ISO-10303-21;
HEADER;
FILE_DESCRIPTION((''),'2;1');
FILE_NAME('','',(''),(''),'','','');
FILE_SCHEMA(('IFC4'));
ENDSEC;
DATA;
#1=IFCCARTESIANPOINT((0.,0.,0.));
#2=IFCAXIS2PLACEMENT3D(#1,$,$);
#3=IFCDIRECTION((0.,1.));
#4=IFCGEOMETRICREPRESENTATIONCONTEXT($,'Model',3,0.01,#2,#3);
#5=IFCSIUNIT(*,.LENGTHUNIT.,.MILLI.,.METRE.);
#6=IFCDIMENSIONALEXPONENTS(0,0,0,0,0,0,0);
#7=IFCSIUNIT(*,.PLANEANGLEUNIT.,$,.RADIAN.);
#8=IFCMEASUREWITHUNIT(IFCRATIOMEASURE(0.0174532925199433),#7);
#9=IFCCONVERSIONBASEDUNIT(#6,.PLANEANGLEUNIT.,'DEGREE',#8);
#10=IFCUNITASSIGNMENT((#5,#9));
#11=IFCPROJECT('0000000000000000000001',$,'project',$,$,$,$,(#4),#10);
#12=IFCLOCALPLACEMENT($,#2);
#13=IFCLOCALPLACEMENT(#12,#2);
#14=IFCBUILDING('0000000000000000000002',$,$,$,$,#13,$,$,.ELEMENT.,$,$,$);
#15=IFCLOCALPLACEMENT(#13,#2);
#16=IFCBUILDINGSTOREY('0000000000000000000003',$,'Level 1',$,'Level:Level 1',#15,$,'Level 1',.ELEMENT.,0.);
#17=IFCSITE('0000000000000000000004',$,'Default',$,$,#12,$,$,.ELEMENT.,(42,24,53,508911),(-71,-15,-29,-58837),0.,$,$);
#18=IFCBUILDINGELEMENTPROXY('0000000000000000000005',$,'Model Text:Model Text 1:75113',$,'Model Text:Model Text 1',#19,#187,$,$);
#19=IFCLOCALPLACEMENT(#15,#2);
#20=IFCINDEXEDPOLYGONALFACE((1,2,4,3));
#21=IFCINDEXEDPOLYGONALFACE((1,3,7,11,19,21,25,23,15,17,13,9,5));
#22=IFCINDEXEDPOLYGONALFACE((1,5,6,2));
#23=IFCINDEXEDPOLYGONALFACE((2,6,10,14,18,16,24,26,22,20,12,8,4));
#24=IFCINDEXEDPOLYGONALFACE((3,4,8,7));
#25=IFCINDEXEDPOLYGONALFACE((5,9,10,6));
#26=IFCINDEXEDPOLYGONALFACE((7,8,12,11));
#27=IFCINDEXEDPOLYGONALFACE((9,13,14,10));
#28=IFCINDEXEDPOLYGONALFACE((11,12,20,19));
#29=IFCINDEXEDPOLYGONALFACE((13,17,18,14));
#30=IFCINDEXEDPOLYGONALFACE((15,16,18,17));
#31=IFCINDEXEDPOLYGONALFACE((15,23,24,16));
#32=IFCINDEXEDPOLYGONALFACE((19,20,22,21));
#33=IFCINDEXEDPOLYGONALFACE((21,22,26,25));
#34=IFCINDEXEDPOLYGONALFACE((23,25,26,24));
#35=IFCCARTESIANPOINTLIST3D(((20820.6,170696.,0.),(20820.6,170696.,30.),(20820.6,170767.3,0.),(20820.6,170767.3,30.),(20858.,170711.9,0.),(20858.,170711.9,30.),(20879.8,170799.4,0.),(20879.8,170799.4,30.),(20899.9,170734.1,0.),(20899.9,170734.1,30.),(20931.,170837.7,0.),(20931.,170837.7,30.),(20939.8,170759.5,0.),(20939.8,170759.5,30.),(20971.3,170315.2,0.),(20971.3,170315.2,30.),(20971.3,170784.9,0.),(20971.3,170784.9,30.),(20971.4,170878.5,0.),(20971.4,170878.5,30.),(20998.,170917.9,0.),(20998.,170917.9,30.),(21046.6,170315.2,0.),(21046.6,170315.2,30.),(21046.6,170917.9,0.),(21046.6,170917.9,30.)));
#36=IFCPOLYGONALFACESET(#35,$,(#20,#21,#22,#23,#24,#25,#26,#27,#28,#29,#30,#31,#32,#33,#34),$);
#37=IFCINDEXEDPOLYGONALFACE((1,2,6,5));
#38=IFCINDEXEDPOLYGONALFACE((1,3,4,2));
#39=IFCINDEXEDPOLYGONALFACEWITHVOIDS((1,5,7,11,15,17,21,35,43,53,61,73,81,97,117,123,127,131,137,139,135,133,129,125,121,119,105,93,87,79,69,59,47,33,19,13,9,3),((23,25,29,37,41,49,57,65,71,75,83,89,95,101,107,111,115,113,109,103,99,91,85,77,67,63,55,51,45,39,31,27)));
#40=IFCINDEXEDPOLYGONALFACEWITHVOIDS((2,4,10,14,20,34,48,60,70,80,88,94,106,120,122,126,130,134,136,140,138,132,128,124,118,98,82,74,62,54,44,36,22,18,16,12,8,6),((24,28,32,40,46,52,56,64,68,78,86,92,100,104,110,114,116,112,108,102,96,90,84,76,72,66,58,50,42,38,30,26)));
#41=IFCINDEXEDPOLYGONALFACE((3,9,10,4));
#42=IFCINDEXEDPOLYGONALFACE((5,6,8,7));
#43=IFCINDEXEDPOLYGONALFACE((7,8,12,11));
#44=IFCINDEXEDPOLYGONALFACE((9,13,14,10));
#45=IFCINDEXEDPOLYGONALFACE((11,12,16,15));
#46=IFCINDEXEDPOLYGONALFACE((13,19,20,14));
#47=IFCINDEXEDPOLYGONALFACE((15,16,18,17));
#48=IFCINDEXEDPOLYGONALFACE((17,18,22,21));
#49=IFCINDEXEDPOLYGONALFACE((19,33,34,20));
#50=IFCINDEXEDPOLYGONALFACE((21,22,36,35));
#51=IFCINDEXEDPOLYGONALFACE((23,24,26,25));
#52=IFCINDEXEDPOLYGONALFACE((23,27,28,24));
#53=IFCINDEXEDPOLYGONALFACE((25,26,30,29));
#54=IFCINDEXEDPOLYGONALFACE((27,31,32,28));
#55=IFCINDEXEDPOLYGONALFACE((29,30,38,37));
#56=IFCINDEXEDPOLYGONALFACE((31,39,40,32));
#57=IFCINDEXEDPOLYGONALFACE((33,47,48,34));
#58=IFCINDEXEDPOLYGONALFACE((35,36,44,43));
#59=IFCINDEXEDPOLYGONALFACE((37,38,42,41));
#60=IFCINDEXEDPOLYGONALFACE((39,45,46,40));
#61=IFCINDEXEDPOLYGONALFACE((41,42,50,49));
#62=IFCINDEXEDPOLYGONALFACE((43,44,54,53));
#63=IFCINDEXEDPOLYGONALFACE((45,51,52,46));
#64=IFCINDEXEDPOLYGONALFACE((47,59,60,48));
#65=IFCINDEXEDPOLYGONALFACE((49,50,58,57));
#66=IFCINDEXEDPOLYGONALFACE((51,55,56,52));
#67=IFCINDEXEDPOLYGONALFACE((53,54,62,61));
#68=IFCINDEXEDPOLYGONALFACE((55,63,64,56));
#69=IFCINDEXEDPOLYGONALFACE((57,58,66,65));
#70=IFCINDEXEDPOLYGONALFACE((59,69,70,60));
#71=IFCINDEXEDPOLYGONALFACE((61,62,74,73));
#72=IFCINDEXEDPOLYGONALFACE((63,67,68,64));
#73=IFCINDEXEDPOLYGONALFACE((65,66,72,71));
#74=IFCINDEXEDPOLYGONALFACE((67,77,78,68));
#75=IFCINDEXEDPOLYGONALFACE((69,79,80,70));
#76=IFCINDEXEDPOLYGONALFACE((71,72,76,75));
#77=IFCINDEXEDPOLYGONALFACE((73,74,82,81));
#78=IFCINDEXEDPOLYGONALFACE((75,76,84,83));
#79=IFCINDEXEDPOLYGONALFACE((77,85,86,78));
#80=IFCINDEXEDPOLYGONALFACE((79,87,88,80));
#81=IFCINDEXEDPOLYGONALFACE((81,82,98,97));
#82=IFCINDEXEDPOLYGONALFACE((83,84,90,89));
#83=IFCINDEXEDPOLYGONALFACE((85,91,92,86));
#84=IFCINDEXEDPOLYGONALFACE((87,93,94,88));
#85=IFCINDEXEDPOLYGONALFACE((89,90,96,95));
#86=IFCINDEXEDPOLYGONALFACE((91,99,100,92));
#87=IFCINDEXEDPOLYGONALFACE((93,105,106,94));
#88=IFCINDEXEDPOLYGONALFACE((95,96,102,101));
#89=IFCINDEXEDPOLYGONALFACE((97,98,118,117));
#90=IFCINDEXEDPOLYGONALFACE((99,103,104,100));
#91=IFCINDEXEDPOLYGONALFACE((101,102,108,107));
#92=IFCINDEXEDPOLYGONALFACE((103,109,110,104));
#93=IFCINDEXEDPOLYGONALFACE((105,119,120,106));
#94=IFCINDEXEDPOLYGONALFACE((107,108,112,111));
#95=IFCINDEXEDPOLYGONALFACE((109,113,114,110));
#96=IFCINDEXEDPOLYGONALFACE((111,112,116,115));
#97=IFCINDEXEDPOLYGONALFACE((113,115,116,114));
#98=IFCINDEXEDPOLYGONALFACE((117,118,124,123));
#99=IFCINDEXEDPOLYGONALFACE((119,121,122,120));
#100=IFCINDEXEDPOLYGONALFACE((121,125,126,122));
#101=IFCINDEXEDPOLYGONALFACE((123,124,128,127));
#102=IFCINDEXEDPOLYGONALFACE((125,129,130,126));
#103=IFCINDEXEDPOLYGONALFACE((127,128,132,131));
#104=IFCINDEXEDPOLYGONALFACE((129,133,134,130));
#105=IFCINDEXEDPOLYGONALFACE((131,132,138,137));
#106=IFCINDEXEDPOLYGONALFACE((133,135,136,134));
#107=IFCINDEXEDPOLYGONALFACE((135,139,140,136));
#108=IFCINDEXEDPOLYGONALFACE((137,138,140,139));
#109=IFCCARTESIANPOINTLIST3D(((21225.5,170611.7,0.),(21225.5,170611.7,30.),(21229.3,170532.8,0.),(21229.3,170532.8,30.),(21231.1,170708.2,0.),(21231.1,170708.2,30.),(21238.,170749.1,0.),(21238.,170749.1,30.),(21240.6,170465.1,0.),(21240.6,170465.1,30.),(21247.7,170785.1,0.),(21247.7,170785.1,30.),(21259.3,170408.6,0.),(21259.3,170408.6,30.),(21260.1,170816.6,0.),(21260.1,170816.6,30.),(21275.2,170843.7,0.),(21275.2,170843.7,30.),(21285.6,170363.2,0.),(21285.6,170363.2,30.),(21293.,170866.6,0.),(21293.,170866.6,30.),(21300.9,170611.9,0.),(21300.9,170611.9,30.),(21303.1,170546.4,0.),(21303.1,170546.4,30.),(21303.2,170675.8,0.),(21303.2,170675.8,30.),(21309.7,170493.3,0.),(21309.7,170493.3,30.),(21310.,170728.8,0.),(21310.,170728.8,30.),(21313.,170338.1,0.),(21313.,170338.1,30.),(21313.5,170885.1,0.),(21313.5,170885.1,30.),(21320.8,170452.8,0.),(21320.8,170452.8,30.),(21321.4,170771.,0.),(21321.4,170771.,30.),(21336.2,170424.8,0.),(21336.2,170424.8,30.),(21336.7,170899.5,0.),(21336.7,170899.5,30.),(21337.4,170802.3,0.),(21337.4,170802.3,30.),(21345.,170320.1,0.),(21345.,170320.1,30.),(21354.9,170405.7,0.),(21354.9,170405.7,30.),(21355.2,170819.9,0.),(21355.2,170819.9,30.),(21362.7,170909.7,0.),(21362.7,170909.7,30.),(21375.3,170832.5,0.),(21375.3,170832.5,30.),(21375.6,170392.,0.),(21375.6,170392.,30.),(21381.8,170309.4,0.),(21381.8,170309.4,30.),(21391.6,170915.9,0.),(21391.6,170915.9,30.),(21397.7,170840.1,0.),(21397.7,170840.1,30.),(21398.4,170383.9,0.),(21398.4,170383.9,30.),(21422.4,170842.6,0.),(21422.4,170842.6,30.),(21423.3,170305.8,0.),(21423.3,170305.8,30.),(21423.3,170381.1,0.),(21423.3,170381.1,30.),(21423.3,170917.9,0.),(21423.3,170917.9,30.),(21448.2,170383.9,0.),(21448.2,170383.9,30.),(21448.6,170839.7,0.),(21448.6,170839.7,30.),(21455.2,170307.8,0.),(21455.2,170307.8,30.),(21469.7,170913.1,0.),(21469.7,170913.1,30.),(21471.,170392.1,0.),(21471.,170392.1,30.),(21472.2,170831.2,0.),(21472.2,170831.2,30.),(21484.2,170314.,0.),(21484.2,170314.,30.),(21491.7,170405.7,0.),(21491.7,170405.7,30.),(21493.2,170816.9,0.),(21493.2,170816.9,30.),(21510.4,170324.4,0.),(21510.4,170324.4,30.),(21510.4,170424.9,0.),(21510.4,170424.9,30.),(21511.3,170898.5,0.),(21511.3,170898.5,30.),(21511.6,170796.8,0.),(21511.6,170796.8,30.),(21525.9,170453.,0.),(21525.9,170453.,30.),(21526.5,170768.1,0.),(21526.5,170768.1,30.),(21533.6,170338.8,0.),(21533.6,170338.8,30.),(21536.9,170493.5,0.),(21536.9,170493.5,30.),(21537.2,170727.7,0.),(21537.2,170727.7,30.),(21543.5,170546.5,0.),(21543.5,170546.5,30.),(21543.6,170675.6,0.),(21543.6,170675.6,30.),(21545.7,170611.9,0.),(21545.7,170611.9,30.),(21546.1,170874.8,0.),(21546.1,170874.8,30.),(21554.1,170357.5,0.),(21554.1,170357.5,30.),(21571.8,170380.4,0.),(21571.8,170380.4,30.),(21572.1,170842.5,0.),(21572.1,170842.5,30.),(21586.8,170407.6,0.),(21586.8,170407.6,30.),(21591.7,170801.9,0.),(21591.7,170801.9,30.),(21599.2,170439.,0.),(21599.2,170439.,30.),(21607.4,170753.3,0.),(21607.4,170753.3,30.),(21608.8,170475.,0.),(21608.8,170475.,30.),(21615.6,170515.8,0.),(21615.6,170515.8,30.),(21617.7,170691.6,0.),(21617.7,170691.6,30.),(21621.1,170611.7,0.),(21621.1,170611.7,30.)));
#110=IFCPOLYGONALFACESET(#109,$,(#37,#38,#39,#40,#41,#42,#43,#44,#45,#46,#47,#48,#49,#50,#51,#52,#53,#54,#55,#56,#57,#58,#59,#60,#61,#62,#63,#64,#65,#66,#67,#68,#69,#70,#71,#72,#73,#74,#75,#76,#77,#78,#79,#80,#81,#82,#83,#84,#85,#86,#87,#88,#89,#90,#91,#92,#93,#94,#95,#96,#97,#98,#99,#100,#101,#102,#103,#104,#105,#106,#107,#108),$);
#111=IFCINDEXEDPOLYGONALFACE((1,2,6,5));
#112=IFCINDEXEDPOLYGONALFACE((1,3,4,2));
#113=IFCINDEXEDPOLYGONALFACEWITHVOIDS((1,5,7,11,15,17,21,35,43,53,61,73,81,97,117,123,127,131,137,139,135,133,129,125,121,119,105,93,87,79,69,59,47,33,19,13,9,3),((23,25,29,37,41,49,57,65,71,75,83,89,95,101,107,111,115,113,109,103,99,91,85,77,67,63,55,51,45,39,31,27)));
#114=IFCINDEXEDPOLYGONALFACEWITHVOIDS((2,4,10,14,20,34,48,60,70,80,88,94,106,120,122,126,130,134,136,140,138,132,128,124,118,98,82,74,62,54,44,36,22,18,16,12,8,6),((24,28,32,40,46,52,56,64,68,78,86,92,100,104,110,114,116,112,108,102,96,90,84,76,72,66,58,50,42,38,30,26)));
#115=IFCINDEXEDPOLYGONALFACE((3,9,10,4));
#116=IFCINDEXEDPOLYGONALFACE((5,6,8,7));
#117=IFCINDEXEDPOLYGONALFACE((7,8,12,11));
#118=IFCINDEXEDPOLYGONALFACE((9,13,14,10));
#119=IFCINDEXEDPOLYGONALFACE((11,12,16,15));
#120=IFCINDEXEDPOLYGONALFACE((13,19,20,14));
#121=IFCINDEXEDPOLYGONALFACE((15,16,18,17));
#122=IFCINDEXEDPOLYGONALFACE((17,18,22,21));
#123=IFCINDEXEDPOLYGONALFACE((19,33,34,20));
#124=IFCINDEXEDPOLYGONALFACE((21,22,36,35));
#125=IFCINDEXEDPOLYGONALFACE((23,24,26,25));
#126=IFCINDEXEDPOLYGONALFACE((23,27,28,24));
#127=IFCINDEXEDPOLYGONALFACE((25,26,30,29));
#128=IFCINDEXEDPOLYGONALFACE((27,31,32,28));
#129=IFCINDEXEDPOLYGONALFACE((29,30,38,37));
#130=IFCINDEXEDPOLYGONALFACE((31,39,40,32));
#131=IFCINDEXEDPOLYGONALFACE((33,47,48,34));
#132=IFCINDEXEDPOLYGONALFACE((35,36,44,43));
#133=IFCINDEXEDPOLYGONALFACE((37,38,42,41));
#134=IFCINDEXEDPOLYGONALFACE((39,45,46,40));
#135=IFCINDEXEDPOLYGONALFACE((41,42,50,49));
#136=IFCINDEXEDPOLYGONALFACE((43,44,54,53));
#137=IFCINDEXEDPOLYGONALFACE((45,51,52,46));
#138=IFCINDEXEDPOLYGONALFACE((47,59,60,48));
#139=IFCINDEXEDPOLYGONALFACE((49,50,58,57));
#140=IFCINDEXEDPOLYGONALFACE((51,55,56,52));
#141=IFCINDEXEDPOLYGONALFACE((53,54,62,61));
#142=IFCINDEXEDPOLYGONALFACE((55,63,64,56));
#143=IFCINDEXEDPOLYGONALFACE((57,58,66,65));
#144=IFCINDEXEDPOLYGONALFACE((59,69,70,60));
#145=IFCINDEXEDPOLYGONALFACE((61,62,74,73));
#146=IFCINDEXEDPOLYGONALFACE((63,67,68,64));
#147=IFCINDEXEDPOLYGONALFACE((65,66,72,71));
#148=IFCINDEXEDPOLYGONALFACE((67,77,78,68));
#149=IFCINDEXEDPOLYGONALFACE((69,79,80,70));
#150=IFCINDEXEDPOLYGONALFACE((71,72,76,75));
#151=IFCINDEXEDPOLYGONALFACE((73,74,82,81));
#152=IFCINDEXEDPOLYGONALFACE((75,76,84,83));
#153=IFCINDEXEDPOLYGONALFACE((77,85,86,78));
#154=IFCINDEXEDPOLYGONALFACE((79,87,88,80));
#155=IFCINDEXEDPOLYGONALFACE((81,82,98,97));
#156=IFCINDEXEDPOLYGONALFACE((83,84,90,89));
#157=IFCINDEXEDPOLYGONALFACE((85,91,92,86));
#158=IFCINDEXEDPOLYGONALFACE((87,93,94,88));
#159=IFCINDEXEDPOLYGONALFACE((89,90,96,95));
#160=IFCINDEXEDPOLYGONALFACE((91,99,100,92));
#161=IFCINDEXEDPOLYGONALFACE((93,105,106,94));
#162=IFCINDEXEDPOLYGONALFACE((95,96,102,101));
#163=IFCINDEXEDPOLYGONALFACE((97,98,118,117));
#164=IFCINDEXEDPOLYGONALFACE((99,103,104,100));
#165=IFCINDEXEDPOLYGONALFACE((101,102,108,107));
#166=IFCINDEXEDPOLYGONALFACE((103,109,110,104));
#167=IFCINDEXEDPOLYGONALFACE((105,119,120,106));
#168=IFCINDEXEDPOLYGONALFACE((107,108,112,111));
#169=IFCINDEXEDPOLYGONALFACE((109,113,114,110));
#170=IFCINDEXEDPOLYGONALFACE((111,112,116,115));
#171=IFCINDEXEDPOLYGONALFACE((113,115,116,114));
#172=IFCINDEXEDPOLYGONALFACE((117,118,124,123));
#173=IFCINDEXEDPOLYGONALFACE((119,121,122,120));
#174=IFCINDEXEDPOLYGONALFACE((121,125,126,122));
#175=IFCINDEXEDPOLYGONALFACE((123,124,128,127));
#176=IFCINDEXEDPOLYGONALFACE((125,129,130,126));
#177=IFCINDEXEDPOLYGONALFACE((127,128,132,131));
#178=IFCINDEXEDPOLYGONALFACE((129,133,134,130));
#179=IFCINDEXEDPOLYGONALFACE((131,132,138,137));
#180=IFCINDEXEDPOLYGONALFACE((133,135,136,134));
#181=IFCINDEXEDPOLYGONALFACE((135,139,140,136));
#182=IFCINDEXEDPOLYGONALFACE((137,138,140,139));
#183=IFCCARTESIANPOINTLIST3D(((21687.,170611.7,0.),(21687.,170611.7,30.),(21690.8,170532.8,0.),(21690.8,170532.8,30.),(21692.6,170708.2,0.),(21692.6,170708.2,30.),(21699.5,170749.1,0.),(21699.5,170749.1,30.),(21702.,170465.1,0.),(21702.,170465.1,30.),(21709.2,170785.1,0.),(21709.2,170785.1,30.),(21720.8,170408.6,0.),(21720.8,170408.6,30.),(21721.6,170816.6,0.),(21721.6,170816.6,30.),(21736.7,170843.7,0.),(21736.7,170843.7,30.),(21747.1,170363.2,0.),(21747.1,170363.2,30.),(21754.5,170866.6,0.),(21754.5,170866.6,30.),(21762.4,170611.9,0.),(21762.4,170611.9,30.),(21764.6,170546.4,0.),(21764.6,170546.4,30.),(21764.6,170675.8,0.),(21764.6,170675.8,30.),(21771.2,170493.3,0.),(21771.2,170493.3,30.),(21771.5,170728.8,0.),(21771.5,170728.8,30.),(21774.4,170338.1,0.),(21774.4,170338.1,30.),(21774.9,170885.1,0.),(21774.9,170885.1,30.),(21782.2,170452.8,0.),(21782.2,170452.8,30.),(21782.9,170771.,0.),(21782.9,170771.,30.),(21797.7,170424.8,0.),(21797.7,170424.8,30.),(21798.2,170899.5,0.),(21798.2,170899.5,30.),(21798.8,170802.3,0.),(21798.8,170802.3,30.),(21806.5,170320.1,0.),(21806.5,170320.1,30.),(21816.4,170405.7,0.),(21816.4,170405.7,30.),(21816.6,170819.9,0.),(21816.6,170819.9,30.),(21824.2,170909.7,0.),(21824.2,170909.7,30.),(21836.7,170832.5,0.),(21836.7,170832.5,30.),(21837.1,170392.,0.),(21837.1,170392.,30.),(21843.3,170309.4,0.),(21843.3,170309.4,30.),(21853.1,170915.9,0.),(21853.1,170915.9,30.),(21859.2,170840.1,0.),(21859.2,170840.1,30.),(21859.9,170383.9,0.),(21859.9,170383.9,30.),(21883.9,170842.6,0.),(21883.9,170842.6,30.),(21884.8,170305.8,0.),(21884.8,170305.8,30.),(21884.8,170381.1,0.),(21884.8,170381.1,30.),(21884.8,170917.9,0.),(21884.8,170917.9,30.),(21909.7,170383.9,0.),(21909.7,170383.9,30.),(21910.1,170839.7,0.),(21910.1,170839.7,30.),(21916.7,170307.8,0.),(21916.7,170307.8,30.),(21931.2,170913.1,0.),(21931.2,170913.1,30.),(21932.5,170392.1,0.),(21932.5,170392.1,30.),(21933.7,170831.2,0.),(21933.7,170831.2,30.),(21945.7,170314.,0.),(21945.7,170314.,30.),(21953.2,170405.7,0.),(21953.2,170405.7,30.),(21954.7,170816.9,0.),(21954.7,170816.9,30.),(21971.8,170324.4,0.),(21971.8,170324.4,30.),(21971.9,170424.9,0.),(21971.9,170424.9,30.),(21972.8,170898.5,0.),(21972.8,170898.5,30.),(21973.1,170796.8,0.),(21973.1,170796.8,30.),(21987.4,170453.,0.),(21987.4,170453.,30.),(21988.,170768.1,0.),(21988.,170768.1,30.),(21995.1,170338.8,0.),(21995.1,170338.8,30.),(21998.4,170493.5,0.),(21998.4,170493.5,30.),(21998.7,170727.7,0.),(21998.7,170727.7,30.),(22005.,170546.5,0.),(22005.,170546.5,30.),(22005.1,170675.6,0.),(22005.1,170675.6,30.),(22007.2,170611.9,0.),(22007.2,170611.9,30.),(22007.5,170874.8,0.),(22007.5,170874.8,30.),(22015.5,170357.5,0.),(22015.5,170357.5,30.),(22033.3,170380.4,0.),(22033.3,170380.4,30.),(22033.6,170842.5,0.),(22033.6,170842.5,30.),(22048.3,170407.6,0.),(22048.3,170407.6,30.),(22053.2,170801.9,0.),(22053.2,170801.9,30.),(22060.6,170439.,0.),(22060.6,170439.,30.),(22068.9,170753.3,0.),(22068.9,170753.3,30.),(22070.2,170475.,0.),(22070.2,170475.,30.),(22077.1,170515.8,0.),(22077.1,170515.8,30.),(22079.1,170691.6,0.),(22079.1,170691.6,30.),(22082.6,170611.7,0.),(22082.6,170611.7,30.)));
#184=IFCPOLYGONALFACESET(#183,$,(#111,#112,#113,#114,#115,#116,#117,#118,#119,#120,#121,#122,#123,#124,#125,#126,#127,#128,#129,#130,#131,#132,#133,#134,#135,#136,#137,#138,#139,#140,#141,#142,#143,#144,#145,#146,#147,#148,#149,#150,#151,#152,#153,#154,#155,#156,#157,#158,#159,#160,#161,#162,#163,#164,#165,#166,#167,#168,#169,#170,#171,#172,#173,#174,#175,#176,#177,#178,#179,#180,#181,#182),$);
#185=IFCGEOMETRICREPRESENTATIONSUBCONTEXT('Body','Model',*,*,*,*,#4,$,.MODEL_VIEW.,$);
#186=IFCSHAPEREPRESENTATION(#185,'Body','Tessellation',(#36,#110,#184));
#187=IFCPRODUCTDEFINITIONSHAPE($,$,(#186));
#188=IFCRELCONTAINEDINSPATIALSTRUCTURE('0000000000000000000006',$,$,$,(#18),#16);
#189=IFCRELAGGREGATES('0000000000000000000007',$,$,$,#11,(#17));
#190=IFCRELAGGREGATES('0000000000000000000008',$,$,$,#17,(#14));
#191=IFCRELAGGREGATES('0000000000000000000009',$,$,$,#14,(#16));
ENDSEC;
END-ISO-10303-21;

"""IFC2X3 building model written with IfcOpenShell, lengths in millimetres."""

from ifc_helpers import new_model, entity, si_unit, converted_unit, direction, frame, origin, place, context, subcontext, project, spatial, polyline, outline, extrude, element, save


model = new_model("IFC2X3")

# Units and contexts
model_context = context("Model", 3, precision=0.01, world=origin(), true_north=direction((0.0, 1.0)))
body_context = subcontext(model_context, "Body", "Model", "MODEL_VIEW")
ifc_project = project(units=[si_unit("LENGTHUNIT", "METRE", prefix="MILLI"), converted_unit("PLANEANGLEUNIT", "DEGREE", entity("IfcRatioMeasure", 0.0174532925199433), si_unit("PLANEANGLEUNIT", "RADIAN"), dimensions=[0, 0, 0, 0, 0, 0, 0])], contexts=[model_context])

# Site, building, storey
site_placement = place(None, origin())
site = spatial("IfcSite", under=ifc_project, at=site_placement, Name="Default", CompositionType="ELEMENT", RefLatitude=(42, 24, 53, 508911), RefLongitude=(-71, -15, -29, -58837), RefElevation=0.0)
building_placement = place(site_placement, origin())
building = spatial("IfcBuilding", under=site, at=building_placement, CompositionType="ELEMENT")
storey_placement = place(building_placement, origin())
storey = spatial("IfcBuildingStorey", under=building, at=storey_placement, Name="Level 1", ObjectType="Level:Level 1", LongName="Level 1", CompositionType="ELEMENT", Elevation=0.0)

# Building element proxy
proxy_1_placement = place(storey_placement, origin())
element("IfcBuildingElementProxy", 1, at=proxy_1_placement, inside=storey, Name="Model Text:Model Text 1:75113", ObjectType="Model Text:Model Text 1", context=body_context, shape_type="SweptSolid", body=[
    extrude(outline(polyline([(-410.6, -111.6), (192.1, -111.6), (192.1, -63.1), (152.7, -36.4), (111.9, 4.0), (73.6, 55.2), (41.4, 114.4), (-29.8, 114.4), (-13.9, 77.0), (8.3, 35.1), (33.7, -4.8), (59.1, -36.3), (-410.6, -36.3), (-410.6, -111.6)])), frame((20935.0, 170725.8, 0.0), z_axis=(0.0, 0.0, 1.0), x_axis=(0.0, 1.0, 0.0)), (0.0, 0.0, 1.0), 30.0),
    extrude(outline(polyline([(-10.6, -198.7), (68.3, -198.7), (136.5, -190.7), (193.9, -174.7), (240.5, -150.6), (266.9, -124.4), (286.3, -93.2), (298.8, -57.0), (304.3, -15.7), (303.8, 16.2), (299.0, 45.5), (289.9, 72.1), (276.6, 96.0), (258.9, 117.3), (236.9, 136.2), (210.4, 152.5), (179.6, 166.3), (144.1, 177.6), (103.7, 186.3), (8.2, 196.4), (-71.8, 196.7), (-134.0, 189.4), (-183.3, 176.1), (-224.7, 158.4), (-258.2, 133.9), (-283.5, 100.3), (-300.1, 59.5), (-307.1, 13.4), (-306.6, -18.4), (-301.8, -47.5), (-292.8, -74.0), (-279.6, -97.9), (-262.0, -119.2), (-240.0, -138.1), (-213.6, -154.5), (-182.8, -168.4), (-147.3, -179.8), (-106.7, -188.6), (-10.6, -198.7)]), holes=[polyline([(-7.2, -123.5), (-71.0, -118.2), (-123.6, -108.8), (-165.2, -95.4), (-195.7, -78.0), (-212.4, -59.4), (-224.1, -38.7), (-230.6, -15.9), (-231.9, 8.9), (-227.8, 35.0), (-218.1, 58.1), (-202.8, 78.4), (-182.0, 95.8), (-152.6, 109.4), (-111.7, 118.1), (-59.4, 122.0), (4.4, 121.1), (69.6, 115.8), (122.2, 106.7), (162.2, 93.7), (189.5, 77.0), (207.7, 57.4), (220.4, 36.0), (227.5, 12.8), (229.1, -12.1), (225.2, -36.8), (215.9, -59.2), (201.3, -79.3), (181.4, -97.1), (152.6, -111.2), (111.6, -120.3), (58.3, -124.4), (-7.2, -123.5)])]), frame((21424.6, 170610.5, 0.0), z_axis=(0.0, 0.0, 1.0), x_axis=(0.047515, -0.998871, 0.0)), (0.0, 0.0, 1.0), 30.0),
    extrude(outline(polyline([(-10.6, -198.7), (68.3, -198.7), (136.5, -190.7), (193.9, -174.7), (240.5, -150.6), (266.9, -124.4), (286.3, -93.2), (298.8, -57.0), (304.3, -15.7), (303.8, 16.2), (299.0, 45.5), (289.9, 72.1), (276.6, 96.0), (258.9, 117.3), (236.9, 136.2), (210.4, 152.5), (179.6, 166.3), (144.1, 177.6), (103.7, 186.3), (8.2, 196.4), (-71.8, 196.7), (-134.0, 189.4), (-183.3, 176.1), (-224.7, 158.4), (-258.2, 133.9), (-283.5, 100.3), (-300.1, 59.5), (-307.1, 13.4), (-306.6, -18.4), (-301.8, -47.5), (-292.8, -74.0), (-279.6, -97.9), (-262.0, -119.2), (-240.0, -138.1), (-213.6, -154.5), (-182.8, -168.4), (-147.3, -179.8), (-106.7, -188.6), (-10.6, -198.7)]), holes=[polyline([(-7.2, -123.5), (-71.0, -118.2), (-123.6, -108.8), (-165.2, -95.4), (-195.7, -78.0), (-212.4, -59.4), (-224.1, -38.7), (-230.6, -15.9), (-231.9, 8.9), (-227.8, 35.0), (-218.1, 58.1), (-202.8, 78.4), (-182.0, 95.8), (-152.6, 109.4), (-111.7, 118.1), (-59.4, 122.0), (4.4, 121.1), (69.6, 115.8), (122.2, 106.7), (162.2, 93.7), (189.5, 77.0), (207.7, 57.4), (220.4, 36.0), (227.5, 12.8), (229.1, -12.1), (225.2, -36.8), (215.9, -59.2), (201.3, -79.3), (181.4, -97.1), (152.6, -111.2), (111.6, -120.3), (58.3, -124.4), (-7.2, -123.5)])]), frame((21886.0, 170610.5, 0.0), z_axis=(0.0, 0.0, 1.0), x_axis=(0.047515, -0.998871, 0.0)), (0.0, 0.0, 1.0), 30.0),
])

save(model, "model.ifc")
